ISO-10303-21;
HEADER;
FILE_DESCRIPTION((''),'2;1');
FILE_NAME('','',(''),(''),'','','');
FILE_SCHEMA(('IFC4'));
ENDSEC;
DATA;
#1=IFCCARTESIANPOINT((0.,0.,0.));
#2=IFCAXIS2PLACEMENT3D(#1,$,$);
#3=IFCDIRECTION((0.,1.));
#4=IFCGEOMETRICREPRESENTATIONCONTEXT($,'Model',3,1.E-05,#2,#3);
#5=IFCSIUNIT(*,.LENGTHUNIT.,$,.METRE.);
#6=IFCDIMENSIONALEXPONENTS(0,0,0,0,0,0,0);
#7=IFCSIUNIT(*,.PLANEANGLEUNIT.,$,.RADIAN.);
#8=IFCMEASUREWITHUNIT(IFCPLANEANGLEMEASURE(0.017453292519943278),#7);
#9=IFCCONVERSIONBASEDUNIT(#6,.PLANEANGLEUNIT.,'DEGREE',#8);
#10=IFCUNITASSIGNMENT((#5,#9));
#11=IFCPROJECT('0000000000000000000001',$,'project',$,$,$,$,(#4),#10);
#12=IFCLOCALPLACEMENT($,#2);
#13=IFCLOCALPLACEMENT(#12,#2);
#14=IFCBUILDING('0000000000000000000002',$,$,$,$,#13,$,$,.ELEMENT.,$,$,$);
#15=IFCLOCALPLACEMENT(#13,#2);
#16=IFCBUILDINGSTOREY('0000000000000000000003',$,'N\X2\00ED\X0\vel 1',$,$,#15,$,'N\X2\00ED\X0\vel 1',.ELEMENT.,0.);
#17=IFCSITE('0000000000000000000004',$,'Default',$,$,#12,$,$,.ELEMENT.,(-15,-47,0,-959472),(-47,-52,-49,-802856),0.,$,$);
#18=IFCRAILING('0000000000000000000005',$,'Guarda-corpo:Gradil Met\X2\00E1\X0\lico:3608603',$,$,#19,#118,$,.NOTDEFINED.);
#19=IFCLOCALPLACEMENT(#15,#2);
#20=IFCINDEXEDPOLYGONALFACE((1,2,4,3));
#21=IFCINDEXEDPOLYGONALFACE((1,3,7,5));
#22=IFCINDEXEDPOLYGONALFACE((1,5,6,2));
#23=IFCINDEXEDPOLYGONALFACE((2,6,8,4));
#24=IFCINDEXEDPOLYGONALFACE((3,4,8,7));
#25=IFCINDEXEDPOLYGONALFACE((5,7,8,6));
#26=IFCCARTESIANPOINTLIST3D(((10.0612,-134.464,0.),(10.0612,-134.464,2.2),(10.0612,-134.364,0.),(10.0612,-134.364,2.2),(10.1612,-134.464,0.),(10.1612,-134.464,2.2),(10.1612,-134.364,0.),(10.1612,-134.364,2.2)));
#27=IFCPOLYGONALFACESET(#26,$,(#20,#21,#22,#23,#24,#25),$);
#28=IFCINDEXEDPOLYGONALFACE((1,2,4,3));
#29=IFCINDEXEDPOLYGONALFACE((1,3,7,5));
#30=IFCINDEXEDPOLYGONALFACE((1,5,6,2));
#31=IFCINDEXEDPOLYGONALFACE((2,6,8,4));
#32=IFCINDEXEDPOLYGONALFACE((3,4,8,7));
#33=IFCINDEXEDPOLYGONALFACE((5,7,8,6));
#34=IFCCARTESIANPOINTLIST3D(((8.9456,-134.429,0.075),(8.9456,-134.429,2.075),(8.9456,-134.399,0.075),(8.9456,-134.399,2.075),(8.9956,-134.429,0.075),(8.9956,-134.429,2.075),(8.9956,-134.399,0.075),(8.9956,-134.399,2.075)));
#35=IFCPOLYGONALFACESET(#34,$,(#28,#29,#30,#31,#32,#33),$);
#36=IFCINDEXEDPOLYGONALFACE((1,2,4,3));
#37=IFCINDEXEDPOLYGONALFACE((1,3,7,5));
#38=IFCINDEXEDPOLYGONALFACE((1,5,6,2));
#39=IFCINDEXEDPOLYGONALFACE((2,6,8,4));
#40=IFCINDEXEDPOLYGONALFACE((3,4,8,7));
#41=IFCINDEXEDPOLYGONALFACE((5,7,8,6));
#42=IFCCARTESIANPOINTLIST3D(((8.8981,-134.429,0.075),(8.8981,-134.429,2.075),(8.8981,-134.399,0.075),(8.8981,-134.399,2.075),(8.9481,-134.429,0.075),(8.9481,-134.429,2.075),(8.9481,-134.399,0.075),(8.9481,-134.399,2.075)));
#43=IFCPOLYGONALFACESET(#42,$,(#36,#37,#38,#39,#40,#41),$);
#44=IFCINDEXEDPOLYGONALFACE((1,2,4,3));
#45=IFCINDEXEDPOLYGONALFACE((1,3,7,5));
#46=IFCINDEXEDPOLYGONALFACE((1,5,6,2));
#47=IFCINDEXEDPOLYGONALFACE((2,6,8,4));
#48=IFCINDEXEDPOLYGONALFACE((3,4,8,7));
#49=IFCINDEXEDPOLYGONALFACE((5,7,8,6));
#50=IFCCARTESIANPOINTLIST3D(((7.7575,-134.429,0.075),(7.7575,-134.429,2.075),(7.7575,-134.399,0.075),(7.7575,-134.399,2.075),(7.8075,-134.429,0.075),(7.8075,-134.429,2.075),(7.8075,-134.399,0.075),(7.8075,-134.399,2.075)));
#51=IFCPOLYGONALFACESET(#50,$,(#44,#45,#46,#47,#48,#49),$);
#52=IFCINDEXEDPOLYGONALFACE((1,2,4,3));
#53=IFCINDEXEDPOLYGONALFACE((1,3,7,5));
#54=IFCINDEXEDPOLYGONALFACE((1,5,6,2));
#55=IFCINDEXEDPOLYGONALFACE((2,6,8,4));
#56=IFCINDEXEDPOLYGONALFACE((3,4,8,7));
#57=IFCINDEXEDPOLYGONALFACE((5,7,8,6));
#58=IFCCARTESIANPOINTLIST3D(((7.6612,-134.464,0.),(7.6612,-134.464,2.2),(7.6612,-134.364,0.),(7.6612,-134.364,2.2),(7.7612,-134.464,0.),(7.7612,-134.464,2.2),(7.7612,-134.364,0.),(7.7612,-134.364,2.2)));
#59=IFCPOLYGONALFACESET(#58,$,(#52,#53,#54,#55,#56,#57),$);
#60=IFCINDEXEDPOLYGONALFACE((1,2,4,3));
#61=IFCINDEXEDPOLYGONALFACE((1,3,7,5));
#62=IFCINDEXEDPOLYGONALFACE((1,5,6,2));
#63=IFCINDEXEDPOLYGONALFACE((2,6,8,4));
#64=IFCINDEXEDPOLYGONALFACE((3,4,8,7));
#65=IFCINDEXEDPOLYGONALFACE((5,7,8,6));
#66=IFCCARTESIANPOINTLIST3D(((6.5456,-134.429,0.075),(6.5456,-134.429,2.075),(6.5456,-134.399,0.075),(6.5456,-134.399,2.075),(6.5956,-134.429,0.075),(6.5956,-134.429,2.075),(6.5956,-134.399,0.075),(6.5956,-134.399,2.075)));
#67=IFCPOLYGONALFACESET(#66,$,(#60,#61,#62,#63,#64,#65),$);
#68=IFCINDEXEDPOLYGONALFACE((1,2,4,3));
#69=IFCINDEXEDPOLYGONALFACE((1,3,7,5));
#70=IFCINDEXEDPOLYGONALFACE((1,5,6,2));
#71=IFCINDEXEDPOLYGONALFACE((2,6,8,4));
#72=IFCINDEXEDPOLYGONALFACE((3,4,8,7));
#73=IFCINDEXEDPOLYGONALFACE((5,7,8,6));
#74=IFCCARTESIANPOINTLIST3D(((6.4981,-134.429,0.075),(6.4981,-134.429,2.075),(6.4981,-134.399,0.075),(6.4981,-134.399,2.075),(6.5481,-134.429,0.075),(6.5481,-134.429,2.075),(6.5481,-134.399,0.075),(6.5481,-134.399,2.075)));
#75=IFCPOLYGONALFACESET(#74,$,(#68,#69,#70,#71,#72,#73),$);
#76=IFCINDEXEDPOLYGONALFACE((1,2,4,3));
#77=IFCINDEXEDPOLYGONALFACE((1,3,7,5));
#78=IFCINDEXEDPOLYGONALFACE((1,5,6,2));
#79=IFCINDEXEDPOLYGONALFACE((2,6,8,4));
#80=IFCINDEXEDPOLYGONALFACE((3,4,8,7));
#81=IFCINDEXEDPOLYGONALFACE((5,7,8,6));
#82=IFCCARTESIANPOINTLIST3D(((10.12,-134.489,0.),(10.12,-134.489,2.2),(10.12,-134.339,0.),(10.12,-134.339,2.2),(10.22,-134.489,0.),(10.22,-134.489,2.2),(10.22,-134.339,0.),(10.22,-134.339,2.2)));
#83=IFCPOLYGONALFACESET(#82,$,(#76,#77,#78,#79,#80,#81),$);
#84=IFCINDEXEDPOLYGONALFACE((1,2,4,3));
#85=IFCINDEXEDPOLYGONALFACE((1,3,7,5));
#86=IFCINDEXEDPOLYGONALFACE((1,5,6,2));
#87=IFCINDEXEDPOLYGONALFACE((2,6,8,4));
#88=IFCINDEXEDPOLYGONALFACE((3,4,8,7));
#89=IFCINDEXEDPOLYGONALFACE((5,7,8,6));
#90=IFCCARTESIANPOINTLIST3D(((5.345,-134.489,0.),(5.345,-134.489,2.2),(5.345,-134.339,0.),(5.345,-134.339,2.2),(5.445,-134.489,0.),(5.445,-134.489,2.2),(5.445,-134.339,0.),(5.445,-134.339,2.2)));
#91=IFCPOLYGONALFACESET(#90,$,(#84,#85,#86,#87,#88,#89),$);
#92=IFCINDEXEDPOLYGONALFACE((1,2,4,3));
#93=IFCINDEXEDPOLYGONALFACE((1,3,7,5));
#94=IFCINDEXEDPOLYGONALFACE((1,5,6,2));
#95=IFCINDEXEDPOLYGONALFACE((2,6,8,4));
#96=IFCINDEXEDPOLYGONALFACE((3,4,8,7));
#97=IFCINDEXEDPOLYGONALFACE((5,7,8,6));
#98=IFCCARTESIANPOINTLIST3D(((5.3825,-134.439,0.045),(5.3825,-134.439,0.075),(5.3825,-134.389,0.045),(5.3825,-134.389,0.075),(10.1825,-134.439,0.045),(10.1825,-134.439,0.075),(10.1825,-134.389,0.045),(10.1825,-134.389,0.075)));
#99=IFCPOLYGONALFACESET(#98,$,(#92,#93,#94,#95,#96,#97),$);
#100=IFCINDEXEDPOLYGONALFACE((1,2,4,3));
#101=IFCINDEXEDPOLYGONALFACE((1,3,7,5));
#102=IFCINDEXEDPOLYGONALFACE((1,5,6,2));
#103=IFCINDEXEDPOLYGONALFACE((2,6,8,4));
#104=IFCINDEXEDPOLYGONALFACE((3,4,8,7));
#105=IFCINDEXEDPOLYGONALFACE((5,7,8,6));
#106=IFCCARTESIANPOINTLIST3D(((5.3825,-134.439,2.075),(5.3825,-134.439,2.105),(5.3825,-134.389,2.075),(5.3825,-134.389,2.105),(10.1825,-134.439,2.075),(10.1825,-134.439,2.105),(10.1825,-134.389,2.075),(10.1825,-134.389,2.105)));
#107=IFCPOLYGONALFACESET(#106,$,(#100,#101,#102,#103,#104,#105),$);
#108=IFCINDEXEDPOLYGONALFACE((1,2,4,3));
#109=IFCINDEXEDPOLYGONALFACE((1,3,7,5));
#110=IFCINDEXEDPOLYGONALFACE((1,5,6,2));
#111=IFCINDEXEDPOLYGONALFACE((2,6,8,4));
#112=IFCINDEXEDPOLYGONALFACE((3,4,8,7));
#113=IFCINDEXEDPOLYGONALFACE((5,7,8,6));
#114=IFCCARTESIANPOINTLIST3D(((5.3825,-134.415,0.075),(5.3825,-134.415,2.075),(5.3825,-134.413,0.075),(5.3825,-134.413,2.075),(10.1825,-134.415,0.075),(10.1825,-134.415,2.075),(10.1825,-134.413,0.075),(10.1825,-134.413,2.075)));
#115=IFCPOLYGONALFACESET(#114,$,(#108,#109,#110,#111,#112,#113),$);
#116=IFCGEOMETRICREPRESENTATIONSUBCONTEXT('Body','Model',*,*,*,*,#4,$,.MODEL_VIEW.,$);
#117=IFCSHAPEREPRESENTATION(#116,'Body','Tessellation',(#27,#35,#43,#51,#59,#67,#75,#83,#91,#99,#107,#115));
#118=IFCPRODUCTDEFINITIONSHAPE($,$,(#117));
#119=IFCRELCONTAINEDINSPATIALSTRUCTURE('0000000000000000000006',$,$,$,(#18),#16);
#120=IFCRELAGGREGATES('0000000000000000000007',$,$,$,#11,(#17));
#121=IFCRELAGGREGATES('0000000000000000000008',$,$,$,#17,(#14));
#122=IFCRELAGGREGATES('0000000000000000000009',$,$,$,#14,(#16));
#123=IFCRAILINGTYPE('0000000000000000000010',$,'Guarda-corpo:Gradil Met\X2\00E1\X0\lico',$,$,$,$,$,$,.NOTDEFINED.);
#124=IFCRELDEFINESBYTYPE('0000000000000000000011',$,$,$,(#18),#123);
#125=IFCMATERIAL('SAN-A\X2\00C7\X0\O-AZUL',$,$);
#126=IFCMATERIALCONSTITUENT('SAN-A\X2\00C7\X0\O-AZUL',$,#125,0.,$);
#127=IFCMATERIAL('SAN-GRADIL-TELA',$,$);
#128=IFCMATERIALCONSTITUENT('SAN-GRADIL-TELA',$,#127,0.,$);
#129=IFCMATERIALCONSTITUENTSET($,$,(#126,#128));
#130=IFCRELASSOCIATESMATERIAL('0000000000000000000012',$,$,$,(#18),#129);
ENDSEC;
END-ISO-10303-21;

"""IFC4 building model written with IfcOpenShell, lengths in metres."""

from ifc_helpers import new_model, entity, si_unit, converted_unit, direction, frame, origin, place, context, subcontext, project, spatial, indexed_curve, outline, extrude, material, constituent, constituent_set, type_object, element, save


model = new_model("IFC4")

# Units and contexts
model_context = context("Model", 3, precision=1e-05, world=origin(), true_north=direction((0.0, 1.0)))
body_context = subcontext(model_context, "Body", "Model", "MODEL_VIEW")
ifc_project = project(units=[si_unit("LENGTHUNIT", "METRE"), converted_unit("PLANEANGLEUNIT", "DEGREE", entity("IfcPlaneAngleMeasure", 0.017453292519943278), si_unit("PLANEANGLEUNIT", "RADIAN"), dimensions=[0, 0, 0, 0, 0, 0, 0])], contexts=[model_context])

# Site, building, storey
site_placement = place(None, origin())
site = spatial("IfcSite", under=ifc_project, at=site_placement, Name="Default", CompositionType="ELEMENT", RefLatitude=(-15, -47, 0, -959472), RefLongitude=(-47, -52, -49, -802856), RefElevation=0.0)
building_placement = place(site_placement, origin())
building = spatial("IfcBuilding", under=site, at=building_placement, CompositionType="ELEMENT")
storey_placement = place(building_placement, origin())
storey = spatial("IfcBuildingStorey", under=building, at=storey_placement, Name="Nível 1", LongName="Nível 1", CompositionType="ELEMENT", Elevation=0.0)

# Shared definitions
ifc_material_1 = material(Name="SAN-AÇO-AZUL")
ifc_material_2 = material(Name="SAN-GRADIL-TELA")

# Railing
ifc_constituent_1 = constituent(ifc_material_1, Name="SAN-AÇO-AZUL", fraction=0.0)
ifc_constituent_2 = constituent(ifc_material_2, Name="SAN-GRADIL-TELA", fraction=0.0)
ifc_constituent_set_1 = constituent_set(constituents=[ifc_constituent_1, ifc_constituent_2])
railing_type = type_object("IfcRailingType", Name="Guarda-corpo:Gradil Metálico", PredefinedType="NOTDEFINED")
railing_1_placement = place(storey_placement, frame((5.345, -134.489, 0.0)))
element("IfcRailing", 1, at=railing_1_placement, inside=storey, type_object=railing_type, material=ifc_constituent_set_1, Name="Guarda-corpo:Gradil Metálico:3608603", PredefinedType="NOTDEFINED", context=body_context, shape_type="SweptSolid", body=[
    extrude(outline(indexed_curve([(-0.05, -0.05), (0.05, -0.05), (0.05, 0.05), (-0.05, 0.05), (-0.05, -0.05)], self_intersect=False)), frame((4.7662, 0.075, 0.0), z_axis=(0.0, 0.0, 1.0), x_axis=(0.0, -1.0, 0.0)), (0.0, 0.0, 1.0), 2.2),
    extrude(outline(indexed_curve([(-0.015, -0.025), (0.015, -0.025), (0.015, 0.025), (-0.015, 0.025), (-0.015, -0.025)], self_intersect=False)), frame((3.6256, 0.075, 0.075), z_axis=(0.0, 0.0, 1.0), x_axis=(0.0, -1.0, 0.0)), (0.0, 0.0, 1.0), 2.0),
    extrude(outline(indexed_curve([(-0.015, -0.025), (0.015, -0.025), (0.015, 0.025), (-0.015, 0.025), (-0.015, -0.025)], self_intersect=False)), frame((3.5781, 0.075, 0.075), z_axis=(0.0, 0.0, 1.0), x_axis=(0.0, -1.0, 0.0)), (0.0, 0.0, 1.0), 2.0),
    extrude(outline(indexed_curve([(-0.015, -0.025), (0.015, -0.025), (0.015, 0.025), (-0.015, 0.025), (-0.015, -0.025)], self_intersect=False)), frame((2.4375, 0.075, 0.075), z_axis=(0.0, 0.0, 1.0), x_axis=(0.0, -1.0, 0.0)), (0.0, 0.0, 1.0), 2.0),
    extrude(outline(indexed_curve([(-0.05, -0.05), (0.05, -0.05), (0.05, 0.05), (-0.05, 0.05), (-0.05, -0.05)], self_intersect=False)), frame((2.3662, 0.075, 0.0), z_axis=(0.0, 0.0, 1.0), x_axis=(0.0, -1.0, 0.0)), (0.0, 0.0, 1.0), 2.2),
    extrude(outline(indexed_curve([(-0.015, -0.025), (0.015, -0.025), (0.015, 0.025), (-0.015, 0.025), (-0.015, -0.025)], self_intersect=False)), frame((1.2256, 0.075, 0.075), z_axis=(0.0, 0.0, 1.0), x_axis=(0.0, -1.0, 0.0)), (0.0, 0.0, 1.0), 2.0),
    extrude(outline(indexed_curve([(-0.015, -0.025), (0.015, -0.025), (0.015, 0.025), (-0.015, 0.025), (-0.015, -0.025)], self_intersect=False)), frame((1.1781, 0.075, 0.075), z_axis=(0.0, 0.0, 1.0), x_axis=(0.0, -1.0, 0.0)), (0.0, 0.0, 1.0), 2.0),
    extrude(outline(indexed_curve([(-0.075, -0.05), (0.075, -0.05), (0.075, 0.05), (-0.075, 0.05), (-0.075, -0.05)], self_intersect=False)), frame((4.825, 0.075, 0.0), z_axis=(0.0, 0.0, 1.0), x_axis=(0.0, -1.0, 0.0)), (0.0, 0.0, 1.0), 2.2),
    extrude(outline(indexed_curve([(-0.075, -0.05), (0.075, -0.05), (0.075, 0.05), (-0.075, 0.05), (-0.075, -0.05)], self_intersect=False)), frame((0.05, 0.075, 0.0), z_axis=(0.0, 0.0, 1.0), x_axis=(0.0, -1.0, 0.0)), (0.0, 0.0, 1.0), 2.2),
    extrude(outline(indexed_curve([(-2.4, -0.025), (2.4, -0.025), (2.4, 0.025), (-2.4, 0.025), (-2.4, -0.025)], self_intersect=False)), frame((2.4375, 0.075, 0.045)), (0.0, 0.0, 1.0), 0.03),
    extrude(outline(indexed_curve([(-2.4, -0.025), (2.4, -0.025), (2.4, 0.025), (-2.4, 0.025), (-2.4, -0.025)], self_intersect=False)), frame((2.4375, 0.075, 2.075)), (0.0, 0.0, 1.0), 0.03),
    extrude(outline(indexed_curve([(-2.4, -0.001), (2.4, -0.001), (2.4, 0.001), (-2.4, 0.001), (-2.4, -0.001)], self_intersect=False)), frame((2.4375, 0.075, 0.075)), (0.0, 0.0, 1.0), 2.0),
])

save(model, "model.ifc")
